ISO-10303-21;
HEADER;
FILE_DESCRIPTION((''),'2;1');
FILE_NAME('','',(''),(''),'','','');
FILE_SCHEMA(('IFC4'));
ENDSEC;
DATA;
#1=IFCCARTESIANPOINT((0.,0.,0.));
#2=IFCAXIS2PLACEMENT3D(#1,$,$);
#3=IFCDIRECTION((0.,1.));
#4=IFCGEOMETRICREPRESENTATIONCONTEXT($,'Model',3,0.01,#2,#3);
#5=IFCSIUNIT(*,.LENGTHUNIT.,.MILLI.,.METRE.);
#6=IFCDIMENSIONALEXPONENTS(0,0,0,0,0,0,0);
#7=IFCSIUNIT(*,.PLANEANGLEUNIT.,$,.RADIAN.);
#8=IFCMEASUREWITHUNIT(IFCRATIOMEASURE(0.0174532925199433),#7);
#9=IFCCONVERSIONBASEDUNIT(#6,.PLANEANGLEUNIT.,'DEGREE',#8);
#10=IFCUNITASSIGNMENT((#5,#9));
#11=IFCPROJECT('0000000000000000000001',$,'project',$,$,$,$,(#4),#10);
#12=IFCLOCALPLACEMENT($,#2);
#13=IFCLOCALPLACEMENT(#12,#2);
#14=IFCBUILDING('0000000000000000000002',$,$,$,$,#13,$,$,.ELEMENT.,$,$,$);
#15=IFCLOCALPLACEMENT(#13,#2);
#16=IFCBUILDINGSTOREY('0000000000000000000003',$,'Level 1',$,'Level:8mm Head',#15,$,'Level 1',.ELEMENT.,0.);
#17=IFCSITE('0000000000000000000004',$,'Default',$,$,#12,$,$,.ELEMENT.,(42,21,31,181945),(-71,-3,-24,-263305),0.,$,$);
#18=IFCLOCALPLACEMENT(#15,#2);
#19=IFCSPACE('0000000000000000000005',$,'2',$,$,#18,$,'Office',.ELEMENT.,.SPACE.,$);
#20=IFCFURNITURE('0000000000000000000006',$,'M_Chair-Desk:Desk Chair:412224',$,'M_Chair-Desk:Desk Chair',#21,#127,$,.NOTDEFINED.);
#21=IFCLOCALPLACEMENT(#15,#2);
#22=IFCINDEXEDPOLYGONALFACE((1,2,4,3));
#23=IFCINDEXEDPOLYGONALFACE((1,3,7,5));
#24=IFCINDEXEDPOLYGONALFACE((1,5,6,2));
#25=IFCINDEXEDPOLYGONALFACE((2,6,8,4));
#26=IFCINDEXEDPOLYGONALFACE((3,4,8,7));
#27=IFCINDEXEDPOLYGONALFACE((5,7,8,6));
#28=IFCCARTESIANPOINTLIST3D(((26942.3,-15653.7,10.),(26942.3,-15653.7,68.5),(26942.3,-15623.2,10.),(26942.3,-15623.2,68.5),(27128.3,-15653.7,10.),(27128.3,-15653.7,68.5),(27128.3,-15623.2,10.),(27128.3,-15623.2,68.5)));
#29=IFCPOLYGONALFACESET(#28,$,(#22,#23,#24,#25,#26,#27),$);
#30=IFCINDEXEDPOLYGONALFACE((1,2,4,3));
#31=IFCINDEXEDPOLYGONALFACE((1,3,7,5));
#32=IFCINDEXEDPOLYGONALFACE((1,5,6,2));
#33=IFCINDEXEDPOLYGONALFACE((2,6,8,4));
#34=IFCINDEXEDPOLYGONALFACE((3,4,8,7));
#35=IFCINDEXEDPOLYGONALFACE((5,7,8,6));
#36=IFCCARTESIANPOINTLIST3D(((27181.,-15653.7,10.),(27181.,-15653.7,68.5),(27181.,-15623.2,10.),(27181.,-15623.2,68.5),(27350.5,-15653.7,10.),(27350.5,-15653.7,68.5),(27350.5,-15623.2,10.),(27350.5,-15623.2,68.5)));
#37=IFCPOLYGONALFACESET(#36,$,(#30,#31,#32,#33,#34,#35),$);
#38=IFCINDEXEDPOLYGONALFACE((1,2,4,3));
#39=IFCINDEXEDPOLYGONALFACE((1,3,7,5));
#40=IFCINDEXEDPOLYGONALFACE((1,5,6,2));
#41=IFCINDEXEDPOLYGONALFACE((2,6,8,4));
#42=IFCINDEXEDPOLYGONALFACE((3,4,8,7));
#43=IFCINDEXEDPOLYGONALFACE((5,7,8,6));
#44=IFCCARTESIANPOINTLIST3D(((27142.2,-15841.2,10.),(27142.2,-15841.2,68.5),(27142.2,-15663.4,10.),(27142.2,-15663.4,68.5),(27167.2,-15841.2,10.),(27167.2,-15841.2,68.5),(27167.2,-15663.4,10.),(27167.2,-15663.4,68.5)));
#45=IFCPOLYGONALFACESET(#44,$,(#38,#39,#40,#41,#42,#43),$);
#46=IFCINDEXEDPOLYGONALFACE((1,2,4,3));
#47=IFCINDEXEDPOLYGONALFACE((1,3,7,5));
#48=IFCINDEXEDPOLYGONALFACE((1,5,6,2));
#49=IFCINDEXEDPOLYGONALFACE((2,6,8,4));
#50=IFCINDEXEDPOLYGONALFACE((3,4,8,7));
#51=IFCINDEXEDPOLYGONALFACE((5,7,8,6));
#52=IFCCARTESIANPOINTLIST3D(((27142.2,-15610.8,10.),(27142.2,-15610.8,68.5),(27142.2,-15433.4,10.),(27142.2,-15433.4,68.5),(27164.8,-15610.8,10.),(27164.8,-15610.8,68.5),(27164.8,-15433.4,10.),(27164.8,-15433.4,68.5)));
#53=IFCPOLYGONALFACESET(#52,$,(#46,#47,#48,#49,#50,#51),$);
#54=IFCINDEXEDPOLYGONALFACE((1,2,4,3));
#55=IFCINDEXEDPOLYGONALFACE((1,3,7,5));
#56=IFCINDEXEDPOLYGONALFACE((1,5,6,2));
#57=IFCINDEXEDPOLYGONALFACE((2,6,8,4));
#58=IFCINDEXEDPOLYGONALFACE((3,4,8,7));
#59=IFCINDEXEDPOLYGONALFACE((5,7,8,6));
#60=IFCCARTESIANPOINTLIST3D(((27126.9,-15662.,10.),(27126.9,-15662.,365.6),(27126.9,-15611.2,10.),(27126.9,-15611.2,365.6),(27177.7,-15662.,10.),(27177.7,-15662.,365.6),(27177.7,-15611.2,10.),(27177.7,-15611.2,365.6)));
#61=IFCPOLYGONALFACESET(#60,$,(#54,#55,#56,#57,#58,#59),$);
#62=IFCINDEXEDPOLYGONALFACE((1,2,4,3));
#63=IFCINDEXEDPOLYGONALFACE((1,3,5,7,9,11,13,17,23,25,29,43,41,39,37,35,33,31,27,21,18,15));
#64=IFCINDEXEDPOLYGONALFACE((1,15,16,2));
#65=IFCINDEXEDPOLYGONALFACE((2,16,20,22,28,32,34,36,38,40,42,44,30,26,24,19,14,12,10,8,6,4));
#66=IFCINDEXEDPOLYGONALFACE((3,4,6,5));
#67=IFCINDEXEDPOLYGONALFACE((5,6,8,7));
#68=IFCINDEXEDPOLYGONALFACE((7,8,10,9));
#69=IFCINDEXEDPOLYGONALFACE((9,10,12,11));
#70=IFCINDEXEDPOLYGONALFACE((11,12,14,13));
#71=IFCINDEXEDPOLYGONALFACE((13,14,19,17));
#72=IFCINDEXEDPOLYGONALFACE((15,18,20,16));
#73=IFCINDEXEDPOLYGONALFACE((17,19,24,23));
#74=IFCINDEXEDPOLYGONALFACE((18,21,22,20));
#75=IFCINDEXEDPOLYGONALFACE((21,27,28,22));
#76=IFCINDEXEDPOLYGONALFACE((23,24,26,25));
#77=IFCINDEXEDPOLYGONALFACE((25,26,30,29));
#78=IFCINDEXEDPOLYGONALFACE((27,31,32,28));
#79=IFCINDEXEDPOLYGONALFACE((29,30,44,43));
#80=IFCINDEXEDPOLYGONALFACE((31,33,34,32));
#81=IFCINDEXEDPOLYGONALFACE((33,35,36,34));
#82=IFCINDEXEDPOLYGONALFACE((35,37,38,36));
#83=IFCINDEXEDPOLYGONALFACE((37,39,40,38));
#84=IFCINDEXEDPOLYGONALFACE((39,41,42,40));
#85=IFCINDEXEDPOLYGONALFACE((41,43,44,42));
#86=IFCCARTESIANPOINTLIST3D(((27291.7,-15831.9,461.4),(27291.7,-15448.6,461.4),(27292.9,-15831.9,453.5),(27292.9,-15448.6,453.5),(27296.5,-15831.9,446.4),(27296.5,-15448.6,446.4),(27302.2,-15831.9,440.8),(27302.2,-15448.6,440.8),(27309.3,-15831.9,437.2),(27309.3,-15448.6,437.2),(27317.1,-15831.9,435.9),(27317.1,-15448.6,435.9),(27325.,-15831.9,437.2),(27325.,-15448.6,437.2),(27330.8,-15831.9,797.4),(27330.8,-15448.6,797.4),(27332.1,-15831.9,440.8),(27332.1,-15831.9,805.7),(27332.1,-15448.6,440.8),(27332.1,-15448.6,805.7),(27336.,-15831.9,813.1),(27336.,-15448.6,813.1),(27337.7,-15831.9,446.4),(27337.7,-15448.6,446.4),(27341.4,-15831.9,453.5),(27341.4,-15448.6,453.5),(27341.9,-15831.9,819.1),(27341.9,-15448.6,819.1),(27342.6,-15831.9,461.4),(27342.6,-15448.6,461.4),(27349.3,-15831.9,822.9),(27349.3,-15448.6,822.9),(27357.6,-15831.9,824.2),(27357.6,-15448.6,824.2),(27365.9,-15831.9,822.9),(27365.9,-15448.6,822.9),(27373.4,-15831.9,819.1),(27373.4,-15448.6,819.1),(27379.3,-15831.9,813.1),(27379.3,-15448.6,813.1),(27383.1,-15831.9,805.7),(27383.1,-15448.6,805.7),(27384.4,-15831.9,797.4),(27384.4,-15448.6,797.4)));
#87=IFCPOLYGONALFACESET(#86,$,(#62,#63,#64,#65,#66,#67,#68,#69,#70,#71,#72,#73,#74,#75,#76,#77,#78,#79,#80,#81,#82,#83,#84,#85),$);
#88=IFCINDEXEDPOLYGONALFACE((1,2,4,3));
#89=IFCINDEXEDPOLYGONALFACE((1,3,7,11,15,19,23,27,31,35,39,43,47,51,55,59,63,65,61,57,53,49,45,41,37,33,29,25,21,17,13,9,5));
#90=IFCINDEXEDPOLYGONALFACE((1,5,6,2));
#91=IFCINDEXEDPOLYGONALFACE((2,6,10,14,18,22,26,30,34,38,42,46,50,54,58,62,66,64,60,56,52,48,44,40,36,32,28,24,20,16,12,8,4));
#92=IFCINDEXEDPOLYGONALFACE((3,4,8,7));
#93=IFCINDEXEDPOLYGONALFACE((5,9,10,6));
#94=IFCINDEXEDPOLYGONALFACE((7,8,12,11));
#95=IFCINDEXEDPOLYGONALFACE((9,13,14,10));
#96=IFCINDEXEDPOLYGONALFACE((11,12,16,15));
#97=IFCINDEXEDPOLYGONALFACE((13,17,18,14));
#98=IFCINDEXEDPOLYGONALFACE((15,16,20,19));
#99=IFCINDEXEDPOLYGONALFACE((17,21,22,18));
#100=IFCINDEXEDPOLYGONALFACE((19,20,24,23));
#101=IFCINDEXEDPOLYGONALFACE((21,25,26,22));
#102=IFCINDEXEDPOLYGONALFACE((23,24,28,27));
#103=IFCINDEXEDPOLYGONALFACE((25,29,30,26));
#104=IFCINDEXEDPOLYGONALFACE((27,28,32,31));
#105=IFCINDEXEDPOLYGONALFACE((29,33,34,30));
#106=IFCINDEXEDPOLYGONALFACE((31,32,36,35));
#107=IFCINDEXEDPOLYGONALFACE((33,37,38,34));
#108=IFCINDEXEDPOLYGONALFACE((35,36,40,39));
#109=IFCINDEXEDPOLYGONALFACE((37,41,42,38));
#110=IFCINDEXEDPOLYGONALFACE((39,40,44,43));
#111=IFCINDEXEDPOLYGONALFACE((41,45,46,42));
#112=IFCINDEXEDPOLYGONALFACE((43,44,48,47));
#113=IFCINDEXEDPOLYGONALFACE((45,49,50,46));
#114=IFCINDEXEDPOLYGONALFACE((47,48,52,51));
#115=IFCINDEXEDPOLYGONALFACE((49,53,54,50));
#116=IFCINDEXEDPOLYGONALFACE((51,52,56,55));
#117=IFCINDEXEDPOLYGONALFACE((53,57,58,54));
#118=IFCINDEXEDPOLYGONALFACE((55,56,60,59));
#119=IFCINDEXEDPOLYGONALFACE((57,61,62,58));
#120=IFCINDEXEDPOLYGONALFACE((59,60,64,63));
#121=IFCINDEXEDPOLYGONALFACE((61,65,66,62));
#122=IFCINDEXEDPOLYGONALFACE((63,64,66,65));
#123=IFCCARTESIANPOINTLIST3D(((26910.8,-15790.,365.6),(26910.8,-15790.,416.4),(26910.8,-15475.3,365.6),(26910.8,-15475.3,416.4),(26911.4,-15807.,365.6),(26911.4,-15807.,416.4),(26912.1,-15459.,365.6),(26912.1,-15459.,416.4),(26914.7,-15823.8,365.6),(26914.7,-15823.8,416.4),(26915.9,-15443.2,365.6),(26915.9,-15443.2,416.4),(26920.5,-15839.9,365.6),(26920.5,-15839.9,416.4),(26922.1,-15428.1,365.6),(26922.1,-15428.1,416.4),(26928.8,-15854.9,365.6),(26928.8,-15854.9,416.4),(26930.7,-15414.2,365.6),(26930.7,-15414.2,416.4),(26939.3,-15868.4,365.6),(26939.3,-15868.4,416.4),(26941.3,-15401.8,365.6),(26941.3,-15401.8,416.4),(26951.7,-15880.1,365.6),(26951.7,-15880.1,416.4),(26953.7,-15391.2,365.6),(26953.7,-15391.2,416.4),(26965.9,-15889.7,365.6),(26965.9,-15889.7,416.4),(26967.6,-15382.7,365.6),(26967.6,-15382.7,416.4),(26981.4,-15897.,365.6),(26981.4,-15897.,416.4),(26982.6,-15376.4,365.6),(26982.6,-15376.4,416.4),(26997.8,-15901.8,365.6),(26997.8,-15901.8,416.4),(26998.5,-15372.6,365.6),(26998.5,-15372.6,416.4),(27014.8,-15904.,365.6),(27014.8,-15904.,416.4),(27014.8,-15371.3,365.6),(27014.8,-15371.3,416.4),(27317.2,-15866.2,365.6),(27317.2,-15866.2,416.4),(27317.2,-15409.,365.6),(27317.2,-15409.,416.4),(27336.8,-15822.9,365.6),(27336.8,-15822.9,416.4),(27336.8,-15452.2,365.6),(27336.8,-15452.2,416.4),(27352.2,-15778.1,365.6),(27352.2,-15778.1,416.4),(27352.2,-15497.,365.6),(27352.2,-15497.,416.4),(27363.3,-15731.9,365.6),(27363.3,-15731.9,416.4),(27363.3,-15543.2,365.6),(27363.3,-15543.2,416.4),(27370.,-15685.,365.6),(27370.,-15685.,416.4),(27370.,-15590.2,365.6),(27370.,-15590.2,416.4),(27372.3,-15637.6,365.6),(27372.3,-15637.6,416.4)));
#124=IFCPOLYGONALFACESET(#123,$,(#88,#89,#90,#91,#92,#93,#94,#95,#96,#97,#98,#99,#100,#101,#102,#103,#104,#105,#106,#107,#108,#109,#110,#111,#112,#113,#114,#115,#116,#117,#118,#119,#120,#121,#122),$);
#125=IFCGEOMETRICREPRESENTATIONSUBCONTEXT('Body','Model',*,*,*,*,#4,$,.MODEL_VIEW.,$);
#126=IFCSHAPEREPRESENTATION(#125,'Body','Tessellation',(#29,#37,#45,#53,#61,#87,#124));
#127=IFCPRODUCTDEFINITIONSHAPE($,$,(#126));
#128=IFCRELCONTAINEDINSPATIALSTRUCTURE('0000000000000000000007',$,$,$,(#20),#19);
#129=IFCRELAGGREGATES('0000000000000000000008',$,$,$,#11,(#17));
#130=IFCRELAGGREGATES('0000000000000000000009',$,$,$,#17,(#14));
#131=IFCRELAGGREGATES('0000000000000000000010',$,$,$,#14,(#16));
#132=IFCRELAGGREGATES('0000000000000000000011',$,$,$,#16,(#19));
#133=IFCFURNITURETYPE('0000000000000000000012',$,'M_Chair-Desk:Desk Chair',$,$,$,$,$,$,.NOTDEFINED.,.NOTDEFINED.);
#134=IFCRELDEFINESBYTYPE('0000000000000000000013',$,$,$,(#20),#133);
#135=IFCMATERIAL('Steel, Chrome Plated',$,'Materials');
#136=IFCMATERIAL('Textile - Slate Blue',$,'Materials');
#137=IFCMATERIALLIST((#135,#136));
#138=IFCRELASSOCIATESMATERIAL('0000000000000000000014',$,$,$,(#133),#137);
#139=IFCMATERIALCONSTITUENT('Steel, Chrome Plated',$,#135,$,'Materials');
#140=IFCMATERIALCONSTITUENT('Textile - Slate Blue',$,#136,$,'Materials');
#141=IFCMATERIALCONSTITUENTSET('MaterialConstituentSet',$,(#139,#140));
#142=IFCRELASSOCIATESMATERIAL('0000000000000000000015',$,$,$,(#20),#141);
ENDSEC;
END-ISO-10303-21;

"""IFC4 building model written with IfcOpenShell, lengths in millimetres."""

from ifc_helpers import new_model, entity, si_unit, converted_unit, direction, frame, origin, place, context, subcontext, project, spatial, indexed_curve, outline, extrude, source, transform, mapped, material, material_list, constituent, constituent_set, type_object, type_shapes, element, save


model = new_model("IFC4")

# Units and contexts
model_context = context("Model", 3, precision=0.01, world=origin(), true_north=direction((0.0, 1.0)))
body_context = subcontext(model_context, "Body", "Model", "MODEL_VIEW")
ifc_project = project(units=[si_unit("LENGTHUNIT", "METRE", prefix="MILLI"), converted_unit("PLANEANGLEUNIT", "DEGREE", entity("IfcRatioMeasure", 0.0174532925199433), si_unit("PLANEANGLEUNIT", "RADIAN"), dimensions=[0, 0, 0, 0, 0, 0, 0])], contexts=[model_context])

# Site, building, storey
site_placement = place(None, origin())
site = spatial("IfcSite", under=ifc_project, at=site_placement, Name="Default", CompositionType="ELEMENT", RefLatitude=(42, 21, 31, 181945), RefLongitude=(-71, -3, -24, -263305), RefElevation=0.0)
building_placement = place(site_placement, origin())
building = spatial("IfcBuilding", under=site, at=building_placement, CompositionType="ELEMENT")
storey_placement = place(building_placement, origin())
storey = spatial("IfcBuildingStorey", under=building, at=storey_placement, Name="Level 1", ObjectType="Level:8mm Head", LongName="Level 1", CompositionType="ELEMENT", Elevation=0.0)

# Shared definitions
space_placement = place(storey_placement, origin())
space = spatial("IfcSpace", under=storey, at=space_placement, Name="2", LongName="Office", CompositionType="ELEMENT", PredefinedType="SPACE")

# Furniture
ifc_material_1 = material(Name="Steel, Chrome Plated", Category="Materials")
ifc_constituent_1 = constituent(ifc_material_1, Name="Steel, Chrome Plated", Category="Materials")
ifc_material_2 = material(Name="Textile - Slate Blue", Category="Materials")
ifc_constituent_2 = constituent(ifc_material_2, Name="Textile - Slate Blue", Category="Materials")
ifc_constituent_set_1 = constituent_set(constituents=[ifc_constituent_1, ifc_constituent_2], Name="MaterialConstituentSet")
ifc_material_list = material_list([ifc_material_1, ifc_material_2])
furniture_type = type_object("IfcFurnitureType", Name="M_Chair-Desk:Desk Chair", AssemblyPlace="NOTDEFINED", PredefinedType="NOTDEFINED", material=ifc_material_list)
shared_shape_1 = source(origin(), body_context, "Body", "SweptSolid", [
    extrude(outline(indexed_curve([(-15.2, -93.0), (15.2, -93.0), (15.2, 93.0), (-15.2, 93.0), (-15.2, -93.0)], self_intersect=False)), frame((-0.9, 281.9, 0.0)), (0.0, 0.0, 1.0), 58.5),
    extrude(outline(indexed_curve([(-15.2, -84.7), (15.2, -84.7), (15.2, 84.7), (-15.2, 84.7), (-15.2, -84.7)], self_intersect=False)), frame((-0.9, 51.5, 0.0), z_axis=(0.0, 0.0, 1.0), x_axis=(-1.0, 0.0, 0.0)), (0.0, 0.0, 1.0), 58.5),
    extrude(outline(indexed_curve([(-12.5, -88.9), (12.5, -88.9), (12.5, 88.9), (-12.5, 88.9), (-12.5, -88.9)], self_intersect=False)), frame((-114.8, 162.5, 0.0), z_axis=(0.0, 0.0, 1.0), x_axis=(0.0, -1.0, 0.0)), (0.0, 0.0, 1.0), 58.5),
    extrude(outline(indexed_curve([(-88.7, -11.3), (88.7, -11.3), (88.7, 11.3), (-88.7, 11.3), (-88.7, -11.3)], self_intersect=False)), frame((115.5, 163.7, 0.0), z_axis=(0.0, 0.0, 1.0), x_axis=(-1.0, 0.0, 0.0)), (0.0, 0.0, 1.0), 58.5),
    extrude(outline(indexed_curve([(-25.4, -25.4), (25.4, -25.4), (25.4, 25.4), (-25.4, 25.4), (-25.4, -25.4)], self_intersect=False)), frame((0.9, 164.9, 0.0), z_axis=(0.0, 0.0, 1.0), x_axis=(-1.0, 0.0, 0.0)), (0.0, 0.0, 1.0), 355.6),
    extrude(outline(indexed_curve([(6.5, 168.0), (5.2, 176.3), (1.4, 183.8), (-4.5, 189.7), (-12.0, 193.5), (-20.2, 194.8), (-28.5, 193.5), (-36.0, 189.7), (-41.9, 183.8), (-45.7, 176.3), (-47.0, 168.0), (-5.2, -168.0), (-4.0, -175.9), (-0.4, -183.0), (5.3, -188.6), (12.4, -192.2), (20.2, -193.5), (28.1, -192.2), (35.2, -188.6), (40.9, -183.0), (44.5, -175.9), (45.7, -168.0), (6.5, 168.0)], self_intersect=False)), frame((-194.4, -20.2, 619.4), z_axis=(1.0, 0.0, 0.0), x_axis=(0.0, 1.0, 0.0)), (0.0, 0.0, 1.0), 383.3),
    extrude(outline(indexed_curve([(-98.9, -257.7), (205.9, -257.7), (230.7, -217.3), (251.6, -174.7), (268.3, -130.3), (280.8, -84.5), (288.9, -37.7), (292.6, 9.6), (291.7, 57.0), (286.4, 104.2), (276.7, 150.6), (262.6, 195.9), (-32.8, 270.8), (-49.1, 271.5), (-65.3, 269.7), (-81.1, 265.4), (-95.9, 258.6), (-109.5, 249.7), (-121.6, 238.7), (-131.8, 225.9), (-139.8, 211.7), (-145.6, 196.5), (-148.9, 180.5), (-187.9, -131.7), (-189.4, -148.8), (-188.3, -165.8), (-184.5, -182.5), (-178.1, -198.4), (-169.4, -213.1), (-158.5, -226.2), (-145.6, -237.5), (-131.2, -246.7), (-115.5, -253.5), (-98.9, -257.7)], self_intersect=False)), frame((1.6, 236.3, 355.6), z_axis=(0.0, 0.0, 1.0), x_axis=(0.124035, -0.992278, 0.0)), (0.0, 0.0, 1.0), 50.8),
])
type_shapes(furniture_type, [shared_shape_1])
furniture_1_placement = place(space_placement, frame((27317.2, -15637.6, 10.0), z_axis=(0.0, 0.0, 1.0), x_axis=(0.0, 1.0, 0.0)))
element("IfcFurniture", 1, at=furniture_1_placement, inside=space, type_object=furniture_type, material=ifc_constituent_set_1, Name="M_Chair-Desk:Desk Chair:412224", ObjectType="M_Chair-Desk:Desk Chair", PredefinedType="NOTDEFINED", context=body_context, shape_type="MappedRepresentation", body=[
    mapped(shared_shape_1, transform((0.0, 0.0, 0.0), scale=1.0)),
])

save(model, "model.ifc")
